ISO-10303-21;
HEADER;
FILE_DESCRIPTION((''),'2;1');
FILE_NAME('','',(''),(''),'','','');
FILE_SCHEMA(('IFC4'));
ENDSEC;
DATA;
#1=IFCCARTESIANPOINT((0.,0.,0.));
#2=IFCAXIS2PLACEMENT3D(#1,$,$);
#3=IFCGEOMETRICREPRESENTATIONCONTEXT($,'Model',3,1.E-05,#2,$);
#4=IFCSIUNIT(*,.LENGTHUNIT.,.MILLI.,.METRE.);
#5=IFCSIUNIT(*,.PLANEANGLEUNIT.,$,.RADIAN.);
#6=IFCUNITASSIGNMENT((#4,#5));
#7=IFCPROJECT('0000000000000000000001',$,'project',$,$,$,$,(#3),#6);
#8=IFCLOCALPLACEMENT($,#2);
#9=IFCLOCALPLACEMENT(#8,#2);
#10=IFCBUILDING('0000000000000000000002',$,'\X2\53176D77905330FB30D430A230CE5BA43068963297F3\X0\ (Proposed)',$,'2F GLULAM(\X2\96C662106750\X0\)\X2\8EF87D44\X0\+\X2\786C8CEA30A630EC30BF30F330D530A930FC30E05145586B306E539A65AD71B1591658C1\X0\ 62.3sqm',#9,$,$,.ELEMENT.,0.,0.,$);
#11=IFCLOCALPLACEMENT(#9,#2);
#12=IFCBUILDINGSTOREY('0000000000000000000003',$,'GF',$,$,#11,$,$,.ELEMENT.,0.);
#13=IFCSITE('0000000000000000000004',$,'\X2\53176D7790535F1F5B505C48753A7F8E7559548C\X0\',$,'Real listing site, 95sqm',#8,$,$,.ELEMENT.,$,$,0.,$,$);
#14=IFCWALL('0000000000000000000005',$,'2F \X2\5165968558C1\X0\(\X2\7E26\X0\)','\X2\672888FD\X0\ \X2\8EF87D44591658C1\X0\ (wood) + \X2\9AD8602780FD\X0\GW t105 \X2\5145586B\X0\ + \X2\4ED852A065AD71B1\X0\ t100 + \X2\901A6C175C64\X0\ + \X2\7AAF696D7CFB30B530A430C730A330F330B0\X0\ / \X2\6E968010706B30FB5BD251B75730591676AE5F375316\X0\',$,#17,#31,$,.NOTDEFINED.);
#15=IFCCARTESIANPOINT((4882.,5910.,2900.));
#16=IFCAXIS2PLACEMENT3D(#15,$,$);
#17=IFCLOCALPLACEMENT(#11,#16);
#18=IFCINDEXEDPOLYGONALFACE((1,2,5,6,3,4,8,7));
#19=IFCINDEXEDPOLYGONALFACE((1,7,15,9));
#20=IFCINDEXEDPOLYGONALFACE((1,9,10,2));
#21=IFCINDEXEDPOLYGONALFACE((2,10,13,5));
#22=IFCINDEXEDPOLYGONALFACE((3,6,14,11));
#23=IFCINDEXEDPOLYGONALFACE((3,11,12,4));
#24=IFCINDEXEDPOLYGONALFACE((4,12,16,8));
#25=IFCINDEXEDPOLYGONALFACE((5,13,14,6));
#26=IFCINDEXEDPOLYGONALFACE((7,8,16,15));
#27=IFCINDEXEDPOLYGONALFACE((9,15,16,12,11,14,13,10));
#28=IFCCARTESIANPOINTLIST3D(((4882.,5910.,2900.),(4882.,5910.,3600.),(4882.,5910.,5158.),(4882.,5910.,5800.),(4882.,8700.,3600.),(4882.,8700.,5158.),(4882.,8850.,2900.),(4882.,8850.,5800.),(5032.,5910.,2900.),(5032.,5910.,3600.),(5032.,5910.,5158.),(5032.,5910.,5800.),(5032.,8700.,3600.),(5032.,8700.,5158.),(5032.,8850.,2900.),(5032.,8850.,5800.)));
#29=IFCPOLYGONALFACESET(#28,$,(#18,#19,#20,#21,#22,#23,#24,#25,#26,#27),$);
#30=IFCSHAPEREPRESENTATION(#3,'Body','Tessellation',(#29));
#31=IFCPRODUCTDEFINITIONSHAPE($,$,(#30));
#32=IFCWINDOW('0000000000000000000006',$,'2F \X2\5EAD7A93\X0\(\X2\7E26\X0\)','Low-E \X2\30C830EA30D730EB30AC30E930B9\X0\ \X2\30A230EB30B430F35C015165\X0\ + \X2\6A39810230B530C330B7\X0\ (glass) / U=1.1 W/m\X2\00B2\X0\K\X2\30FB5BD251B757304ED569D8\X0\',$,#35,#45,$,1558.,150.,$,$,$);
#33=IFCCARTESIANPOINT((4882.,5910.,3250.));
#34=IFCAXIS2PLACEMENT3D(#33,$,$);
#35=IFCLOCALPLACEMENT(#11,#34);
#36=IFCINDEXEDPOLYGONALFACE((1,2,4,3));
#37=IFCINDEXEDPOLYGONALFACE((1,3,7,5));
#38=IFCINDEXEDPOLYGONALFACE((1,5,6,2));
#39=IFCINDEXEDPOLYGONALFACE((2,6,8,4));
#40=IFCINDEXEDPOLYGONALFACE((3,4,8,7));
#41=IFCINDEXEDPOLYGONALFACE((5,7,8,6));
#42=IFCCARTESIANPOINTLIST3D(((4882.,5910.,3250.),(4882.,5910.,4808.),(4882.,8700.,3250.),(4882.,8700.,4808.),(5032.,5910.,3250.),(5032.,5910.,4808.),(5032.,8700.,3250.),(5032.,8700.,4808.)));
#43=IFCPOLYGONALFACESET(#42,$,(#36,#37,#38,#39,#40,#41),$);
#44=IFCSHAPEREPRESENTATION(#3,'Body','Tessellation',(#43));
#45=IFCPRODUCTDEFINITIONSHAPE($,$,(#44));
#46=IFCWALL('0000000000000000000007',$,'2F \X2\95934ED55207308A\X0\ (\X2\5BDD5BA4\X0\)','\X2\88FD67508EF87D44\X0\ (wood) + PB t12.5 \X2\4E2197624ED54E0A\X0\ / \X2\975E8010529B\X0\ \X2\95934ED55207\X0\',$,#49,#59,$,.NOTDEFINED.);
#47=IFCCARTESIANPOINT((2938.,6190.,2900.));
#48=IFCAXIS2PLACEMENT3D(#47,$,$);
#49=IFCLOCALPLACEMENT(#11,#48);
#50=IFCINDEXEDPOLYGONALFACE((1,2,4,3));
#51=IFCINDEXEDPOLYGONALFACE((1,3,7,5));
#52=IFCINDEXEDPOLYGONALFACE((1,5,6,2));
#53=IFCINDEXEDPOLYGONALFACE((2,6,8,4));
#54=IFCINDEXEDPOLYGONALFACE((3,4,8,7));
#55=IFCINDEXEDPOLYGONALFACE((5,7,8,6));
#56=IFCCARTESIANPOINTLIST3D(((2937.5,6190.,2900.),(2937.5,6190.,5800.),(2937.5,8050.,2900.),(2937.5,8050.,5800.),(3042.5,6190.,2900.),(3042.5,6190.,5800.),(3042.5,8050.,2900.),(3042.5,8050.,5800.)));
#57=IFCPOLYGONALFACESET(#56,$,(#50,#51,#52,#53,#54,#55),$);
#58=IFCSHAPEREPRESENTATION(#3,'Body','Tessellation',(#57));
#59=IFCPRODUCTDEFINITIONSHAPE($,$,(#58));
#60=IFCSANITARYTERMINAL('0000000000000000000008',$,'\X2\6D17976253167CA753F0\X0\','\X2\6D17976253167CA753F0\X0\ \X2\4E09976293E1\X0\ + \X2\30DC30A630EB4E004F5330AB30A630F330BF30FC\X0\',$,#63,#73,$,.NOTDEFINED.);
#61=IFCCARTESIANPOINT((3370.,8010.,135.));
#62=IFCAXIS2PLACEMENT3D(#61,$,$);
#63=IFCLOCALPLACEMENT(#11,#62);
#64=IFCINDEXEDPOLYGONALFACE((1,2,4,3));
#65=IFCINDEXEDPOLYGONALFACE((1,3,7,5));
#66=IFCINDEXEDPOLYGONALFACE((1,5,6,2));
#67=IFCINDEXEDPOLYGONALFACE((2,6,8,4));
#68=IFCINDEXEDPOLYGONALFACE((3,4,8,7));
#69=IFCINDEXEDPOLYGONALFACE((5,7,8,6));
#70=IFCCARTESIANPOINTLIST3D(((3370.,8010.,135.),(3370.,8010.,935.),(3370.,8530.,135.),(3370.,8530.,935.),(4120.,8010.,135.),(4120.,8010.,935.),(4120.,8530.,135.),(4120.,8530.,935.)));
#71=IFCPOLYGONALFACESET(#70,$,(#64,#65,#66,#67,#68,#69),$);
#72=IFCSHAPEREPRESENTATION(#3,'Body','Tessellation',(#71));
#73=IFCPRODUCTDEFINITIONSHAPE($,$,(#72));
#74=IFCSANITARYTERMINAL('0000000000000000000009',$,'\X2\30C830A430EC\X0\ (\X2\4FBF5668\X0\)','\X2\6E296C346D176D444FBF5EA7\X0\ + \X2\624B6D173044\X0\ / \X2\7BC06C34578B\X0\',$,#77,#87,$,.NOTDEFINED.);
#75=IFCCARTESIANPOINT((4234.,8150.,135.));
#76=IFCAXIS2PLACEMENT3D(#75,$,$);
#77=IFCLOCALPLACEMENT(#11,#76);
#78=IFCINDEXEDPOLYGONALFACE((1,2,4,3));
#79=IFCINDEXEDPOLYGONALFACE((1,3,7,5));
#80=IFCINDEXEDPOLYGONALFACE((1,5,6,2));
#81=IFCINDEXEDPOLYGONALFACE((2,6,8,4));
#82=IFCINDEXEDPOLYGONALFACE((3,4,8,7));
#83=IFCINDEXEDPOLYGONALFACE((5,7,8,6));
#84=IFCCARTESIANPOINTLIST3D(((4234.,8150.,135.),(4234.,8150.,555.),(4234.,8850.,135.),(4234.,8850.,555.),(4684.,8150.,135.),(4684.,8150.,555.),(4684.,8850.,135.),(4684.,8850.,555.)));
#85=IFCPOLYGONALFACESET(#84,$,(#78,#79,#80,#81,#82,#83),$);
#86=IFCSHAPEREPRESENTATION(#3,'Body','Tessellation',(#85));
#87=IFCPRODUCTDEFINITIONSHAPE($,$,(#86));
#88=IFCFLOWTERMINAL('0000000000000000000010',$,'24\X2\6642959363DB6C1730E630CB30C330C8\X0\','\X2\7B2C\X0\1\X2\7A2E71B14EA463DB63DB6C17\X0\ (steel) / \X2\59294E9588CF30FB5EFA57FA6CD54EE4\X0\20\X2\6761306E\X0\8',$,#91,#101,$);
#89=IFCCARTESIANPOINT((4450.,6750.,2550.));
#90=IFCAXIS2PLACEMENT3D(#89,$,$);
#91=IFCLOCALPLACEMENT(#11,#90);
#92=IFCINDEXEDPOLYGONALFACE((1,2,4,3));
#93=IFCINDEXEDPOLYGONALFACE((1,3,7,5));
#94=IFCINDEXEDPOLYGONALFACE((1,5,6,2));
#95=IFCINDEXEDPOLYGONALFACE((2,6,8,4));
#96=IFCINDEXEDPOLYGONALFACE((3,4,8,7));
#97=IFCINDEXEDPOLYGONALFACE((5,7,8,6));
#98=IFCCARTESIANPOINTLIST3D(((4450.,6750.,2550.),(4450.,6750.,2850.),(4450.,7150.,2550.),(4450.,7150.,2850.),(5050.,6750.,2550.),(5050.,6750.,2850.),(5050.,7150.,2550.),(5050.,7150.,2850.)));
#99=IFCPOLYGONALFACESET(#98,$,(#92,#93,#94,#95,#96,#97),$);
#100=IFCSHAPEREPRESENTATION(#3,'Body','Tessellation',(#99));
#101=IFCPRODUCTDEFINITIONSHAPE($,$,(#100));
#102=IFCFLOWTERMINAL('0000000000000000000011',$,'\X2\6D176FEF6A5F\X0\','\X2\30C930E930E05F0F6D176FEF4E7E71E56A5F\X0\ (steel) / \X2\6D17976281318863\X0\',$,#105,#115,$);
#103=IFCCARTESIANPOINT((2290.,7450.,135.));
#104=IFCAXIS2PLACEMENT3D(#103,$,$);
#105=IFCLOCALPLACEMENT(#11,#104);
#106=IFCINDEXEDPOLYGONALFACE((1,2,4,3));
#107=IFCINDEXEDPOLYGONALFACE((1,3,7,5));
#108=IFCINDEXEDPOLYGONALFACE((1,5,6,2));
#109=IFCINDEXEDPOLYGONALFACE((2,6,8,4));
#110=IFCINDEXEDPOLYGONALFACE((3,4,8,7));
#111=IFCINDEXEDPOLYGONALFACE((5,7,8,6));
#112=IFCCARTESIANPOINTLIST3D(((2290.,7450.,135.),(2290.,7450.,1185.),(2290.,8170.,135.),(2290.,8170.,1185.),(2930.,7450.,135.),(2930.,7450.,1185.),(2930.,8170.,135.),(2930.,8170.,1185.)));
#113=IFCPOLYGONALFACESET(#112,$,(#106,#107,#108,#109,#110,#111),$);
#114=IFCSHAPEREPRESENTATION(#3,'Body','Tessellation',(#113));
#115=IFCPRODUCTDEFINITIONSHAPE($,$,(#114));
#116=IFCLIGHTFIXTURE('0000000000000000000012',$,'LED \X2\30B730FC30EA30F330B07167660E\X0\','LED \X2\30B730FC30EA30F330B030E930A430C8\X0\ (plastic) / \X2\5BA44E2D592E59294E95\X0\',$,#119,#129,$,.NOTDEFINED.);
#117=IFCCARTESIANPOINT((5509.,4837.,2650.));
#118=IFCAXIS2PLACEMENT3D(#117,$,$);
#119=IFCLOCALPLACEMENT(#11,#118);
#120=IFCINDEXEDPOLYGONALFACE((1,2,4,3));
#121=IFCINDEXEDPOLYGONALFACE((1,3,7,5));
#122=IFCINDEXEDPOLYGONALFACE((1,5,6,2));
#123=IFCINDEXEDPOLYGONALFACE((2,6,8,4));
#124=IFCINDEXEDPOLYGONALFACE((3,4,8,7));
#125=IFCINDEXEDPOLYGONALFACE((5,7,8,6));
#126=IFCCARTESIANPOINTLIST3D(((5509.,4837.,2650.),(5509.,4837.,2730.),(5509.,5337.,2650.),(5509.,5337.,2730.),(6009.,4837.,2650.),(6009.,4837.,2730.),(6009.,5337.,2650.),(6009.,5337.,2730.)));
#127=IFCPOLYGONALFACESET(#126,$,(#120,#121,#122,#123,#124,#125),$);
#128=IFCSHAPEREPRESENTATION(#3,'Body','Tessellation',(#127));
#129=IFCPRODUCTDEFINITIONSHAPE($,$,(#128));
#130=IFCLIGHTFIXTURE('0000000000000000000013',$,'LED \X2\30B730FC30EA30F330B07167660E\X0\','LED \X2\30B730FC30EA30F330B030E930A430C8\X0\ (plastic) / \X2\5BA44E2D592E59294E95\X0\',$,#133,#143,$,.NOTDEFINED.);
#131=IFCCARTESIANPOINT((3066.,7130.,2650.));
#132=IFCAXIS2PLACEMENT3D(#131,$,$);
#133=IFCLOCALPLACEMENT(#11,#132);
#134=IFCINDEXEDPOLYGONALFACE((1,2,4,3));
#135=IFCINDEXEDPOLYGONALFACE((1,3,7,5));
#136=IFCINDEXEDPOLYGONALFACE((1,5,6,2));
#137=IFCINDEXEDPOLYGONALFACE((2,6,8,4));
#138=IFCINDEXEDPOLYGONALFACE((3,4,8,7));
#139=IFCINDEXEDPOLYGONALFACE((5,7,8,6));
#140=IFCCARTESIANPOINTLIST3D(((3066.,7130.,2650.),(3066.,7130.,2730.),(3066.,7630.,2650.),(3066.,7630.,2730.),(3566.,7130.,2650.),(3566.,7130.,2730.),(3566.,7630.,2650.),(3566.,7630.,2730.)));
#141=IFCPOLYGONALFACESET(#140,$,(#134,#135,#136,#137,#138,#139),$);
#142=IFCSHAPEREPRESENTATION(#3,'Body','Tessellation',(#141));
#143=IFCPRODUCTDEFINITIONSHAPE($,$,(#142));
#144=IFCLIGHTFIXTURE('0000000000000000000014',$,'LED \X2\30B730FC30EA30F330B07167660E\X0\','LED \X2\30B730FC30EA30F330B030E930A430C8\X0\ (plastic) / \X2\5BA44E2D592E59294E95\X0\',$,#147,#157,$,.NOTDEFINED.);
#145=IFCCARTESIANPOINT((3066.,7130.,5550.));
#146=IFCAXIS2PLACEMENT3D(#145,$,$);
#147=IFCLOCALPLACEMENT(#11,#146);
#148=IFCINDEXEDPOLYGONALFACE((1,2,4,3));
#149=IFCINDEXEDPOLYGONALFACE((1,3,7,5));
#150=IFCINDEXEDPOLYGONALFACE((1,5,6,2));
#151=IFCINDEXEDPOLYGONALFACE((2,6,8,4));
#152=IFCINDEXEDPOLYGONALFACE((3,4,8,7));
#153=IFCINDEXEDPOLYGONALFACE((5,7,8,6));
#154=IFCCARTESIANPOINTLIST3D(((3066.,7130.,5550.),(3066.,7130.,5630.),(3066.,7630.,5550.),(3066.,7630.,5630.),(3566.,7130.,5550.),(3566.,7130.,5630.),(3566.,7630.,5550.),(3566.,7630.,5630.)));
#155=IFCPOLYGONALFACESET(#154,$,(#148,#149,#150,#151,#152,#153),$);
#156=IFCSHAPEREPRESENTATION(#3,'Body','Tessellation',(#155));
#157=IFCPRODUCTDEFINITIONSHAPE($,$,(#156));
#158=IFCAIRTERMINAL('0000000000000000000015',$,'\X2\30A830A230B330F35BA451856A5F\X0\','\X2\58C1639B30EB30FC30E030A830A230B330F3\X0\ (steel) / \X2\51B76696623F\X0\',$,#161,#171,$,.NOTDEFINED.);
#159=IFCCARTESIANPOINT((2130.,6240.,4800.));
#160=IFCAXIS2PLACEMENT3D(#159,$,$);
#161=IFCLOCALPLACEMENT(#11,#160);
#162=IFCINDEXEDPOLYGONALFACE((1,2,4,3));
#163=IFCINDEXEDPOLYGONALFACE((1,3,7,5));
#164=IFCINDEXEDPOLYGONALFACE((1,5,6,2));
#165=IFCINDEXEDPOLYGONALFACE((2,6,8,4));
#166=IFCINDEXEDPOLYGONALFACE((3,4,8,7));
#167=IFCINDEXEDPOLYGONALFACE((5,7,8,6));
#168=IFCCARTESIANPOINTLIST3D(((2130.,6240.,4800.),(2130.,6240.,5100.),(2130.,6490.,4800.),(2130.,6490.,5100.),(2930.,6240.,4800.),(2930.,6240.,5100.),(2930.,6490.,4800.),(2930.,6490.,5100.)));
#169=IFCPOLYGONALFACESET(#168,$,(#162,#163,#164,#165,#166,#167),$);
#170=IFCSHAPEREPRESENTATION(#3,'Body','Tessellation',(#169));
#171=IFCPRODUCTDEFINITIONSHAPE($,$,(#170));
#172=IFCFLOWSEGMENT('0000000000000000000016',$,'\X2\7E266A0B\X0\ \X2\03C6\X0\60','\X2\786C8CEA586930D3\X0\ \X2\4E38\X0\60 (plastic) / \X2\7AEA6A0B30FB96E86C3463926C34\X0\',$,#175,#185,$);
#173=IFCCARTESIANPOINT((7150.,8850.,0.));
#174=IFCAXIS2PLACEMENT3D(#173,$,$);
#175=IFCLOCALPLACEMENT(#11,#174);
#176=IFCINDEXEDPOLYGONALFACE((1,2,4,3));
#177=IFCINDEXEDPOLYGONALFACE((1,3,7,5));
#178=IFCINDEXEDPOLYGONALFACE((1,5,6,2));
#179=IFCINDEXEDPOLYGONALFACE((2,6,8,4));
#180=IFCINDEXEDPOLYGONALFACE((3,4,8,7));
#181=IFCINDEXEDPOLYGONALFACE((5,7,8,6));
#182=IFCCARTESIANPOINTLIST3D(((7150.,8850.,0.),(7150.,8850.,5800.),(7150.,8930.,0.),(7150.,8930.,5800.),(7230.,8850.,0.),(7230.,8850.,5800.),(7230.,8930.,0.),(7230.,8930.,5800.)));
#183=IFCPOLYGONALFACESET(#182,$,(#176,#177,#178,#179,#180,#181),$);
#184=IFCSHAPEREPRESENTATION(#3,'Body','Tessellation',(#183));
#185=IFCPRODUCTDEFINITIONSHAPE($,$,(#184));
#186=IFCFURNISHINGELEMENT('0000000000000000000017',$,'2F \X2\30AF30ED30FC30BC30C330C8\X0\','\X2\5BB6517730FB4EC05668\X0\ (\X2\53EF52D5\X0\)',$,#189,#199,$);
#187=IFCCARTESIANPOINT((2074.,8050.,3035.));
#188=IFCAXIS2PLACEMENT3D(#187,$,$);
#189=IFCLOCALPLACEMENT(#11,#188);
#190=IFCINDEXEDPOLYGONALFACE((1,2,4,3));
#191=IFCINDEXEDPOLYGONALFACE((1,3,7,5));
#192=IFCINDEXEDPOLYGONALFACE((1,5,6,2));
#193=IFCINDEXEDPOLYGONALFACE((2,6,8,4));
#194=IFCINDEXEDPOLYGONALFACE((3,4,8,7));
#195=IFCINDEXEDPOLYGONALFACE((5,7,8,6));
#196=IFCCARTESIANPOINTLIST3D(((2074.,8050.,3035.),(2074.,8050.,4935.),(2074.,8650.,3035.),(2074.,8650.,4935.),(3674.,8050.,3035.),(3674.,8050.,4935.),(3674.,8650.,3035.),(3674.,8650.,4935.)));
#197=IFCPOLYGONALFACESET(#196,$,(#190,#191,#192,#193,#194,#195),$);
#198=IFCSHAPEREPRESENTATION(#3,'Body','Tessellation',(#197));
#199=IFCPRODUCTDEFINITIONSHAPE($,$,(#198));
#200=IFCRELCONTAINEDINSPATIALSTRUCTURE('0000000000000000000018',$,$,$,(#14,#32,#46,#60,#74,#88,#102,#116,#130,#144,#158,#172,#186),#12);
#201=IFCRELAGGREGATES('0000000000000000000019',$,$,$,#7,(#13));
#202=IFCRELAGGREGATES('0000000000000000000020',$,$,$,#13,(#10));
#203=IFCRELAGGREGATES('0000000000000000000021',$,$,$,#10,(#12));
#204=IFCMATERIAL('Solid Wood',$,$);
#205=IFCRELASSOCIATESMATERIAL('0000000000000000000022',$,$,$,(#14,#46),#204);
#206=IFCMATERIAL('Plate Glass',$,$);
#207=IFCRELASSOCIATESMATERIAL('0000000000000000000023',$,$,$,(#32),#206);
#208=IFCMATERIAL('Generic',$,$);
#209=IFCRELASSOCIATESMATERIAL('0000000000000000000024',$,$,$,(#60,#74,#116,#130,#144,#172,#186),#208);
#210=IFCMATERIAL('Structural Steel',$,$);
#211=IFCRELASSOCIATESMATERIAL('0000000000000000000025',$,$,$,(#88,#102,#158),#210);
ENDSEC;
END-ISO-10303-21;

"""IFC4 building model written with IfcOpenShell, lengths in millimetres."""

from ifc_helpers import new_model, si_unit, frame, frame_2d, origin, place, context, project, spatial, rectangle, extrude, material, element, fill, save


model = new_model("IFC4")

# Units and contexts
model_context = context("Model", 3, precision=1e-05, world=origin())
ifc_project = project(units=[si_unit("LENGTHUNIT", "METRE", prefix="MILLI"), si_unit("PLANEANGLEUNIT", "RADIAN")], contexts=[model_context])

# Site, building, storey
site_placement = place(None, origin())
site = spatial("IfcSite", under=ifc_project, at=site_placement, Name="北海道弟子屈町美留和", ObjectType="Real listing site, 95sqm", CompositionType="ELEMENT", RefElevation=0.0)
building_placement = place(site_placement, origin())
building = spatial("IfcBuilding", under=site, at=building_placement, Name="北海道・ピアノ室と防音 (Proposed)", ObjectType="2F GLULAM(集成材)軸組+硬質ウレタンフォーム充填の厚断熱外壁 62.3sqm", CompositionType="ELEMENT", ElevationOfRefHeight=0.0, ElevationOfTerrain=0.0)
storey_placement = place(building_placement, origin())
storey = spatial("IfcBuildingStorey", under=building, at=storey_placement, Name="GF", CompositionType="ELEMENT", Elevation=0.0)

# Shared definitions
ifc_material_1 = material(Name="Solid Wood")

# Shared definitions
ifc_material_2 = material(Name="Plate Glass")

# Wall, opening, window
wall_1_placement = place(storey_placement, frame((4882.0, 5910.0, 2900.0)))
wall_1 = element("IfcWall", 1, at=wall_1_placement, inside=storey, material=ifc_material_1, Name="2F 入隅壁(縦)", Description="木製 軸組外壁 (wood) + 高性能GW t105 充填 + 付加断熱 t100 + 通気層 + 窯業系サイディング / 準耐火・寒冷地外皮強化", PredefinedType="NOTDEFINED", context=model_context, shape_type="SweptSolid", body=[
    extrude(rectangle(XDim=150.0, YDim=2940.0, at=frame_2d((75.0, 1470.0))), frame((4882.0, 5910.0, 2900.0)), (0.0, 0.0, 1.0), 2900.0),
])
opening_1_placement = place(storey_placement, frame((4882.0, 5910.0, 3250.0)))
opening_1 = element("IfcOpeningElement", 2, at=opening_1_placement, cuts=wall_1, PredefinedType="NOTDEFINED", context=model_context, shape_type="SweptSolid", body=[
    extrude(rectangle(XDim=150.0, YDim=2790.0, at=frame_2d((75.0, 1395.0))), frame((4882.0, 5910.0, 3250.0)), (0.0, 0.0, 1.0), 1558.0),
])
window_1_placement = place(storey_placement, frame((4882.0, 5910.0, 3250.0)))
window_1 = element("IfcWindow", 3, at=window_1_placement, inside=storey, material=ifc_material_2, Name="2F 庭窓(縦)", Description="Low-E トリプルガラス アルゴン封入 + 樹脂サッシ (glass) / U=1.1 W/m²K・寒冷地仕様", OverallHeight=1558.0, OverallWidth=150.0, context=model_context, shape_type="SweptSolid", body=[
    extrude(rectangle(XDim=150.0, YDim=2790.0, at=frame_2d((75.0, 1395.0))), frame((4882.0, 5910.0, 3250.0)), (0.0, 0.0, 1.0), 1558.0),
])
fill(opening_1, window_1)

# Wall
wall_2_placement = place(storey_placement, frame((2938.0, 6190.0, 2900.0)))
element("IfcWall", 4, at=wall_2_placement, inside=storey, material=ifc_material_1, Name="2F 間仕切り (寝室)", Description="製材軸組 (wood) + PB t12.5 両面仕上 / 非耐力 間仕切", PredefinedType="NOTDEFINED", context=model_context, shape_type="SweptSolid", body=[
    extrude(rectangle(XDim=105.0, YDim=1860.0, at=frame_2d((52.0, 930.0))), frame((2938.0, 6190.0, 2900.0)), (0.0, 0.0, 1.0), 2900.0),
])

# Sanitary terminals
ifc_material_3 = material(Name="Generic")
sanitary_terminal_1_placement = place(storey_placement, frame((3370.0, 8010.0, 135.0)))
element("IfcSanitaryTerminal", 5, at=sanitary_terminal_1_placement, inside=storey, material=ifc_material_3, Name="洗面化粧台", Description="洗面化粧台 三面鏡 + ボウル一体カウンター", PredefinedType="NOTDEFINED", context=model_context, shape_type="SweptSolid", body=[
    extrude(rectangle(XDim=750.0, YDim=520.0, at=frame_2d((375.0, 260.0))), frame((3370.0, 8010.0, 135.0)), (0.0, 0.0, 1.0), 800.0),
])
sanitary_terminal_2_placement = place(storey_placement, frame((4234.0, 8150.0, 135.0)))
element("IfcSanitaryTerminal", 6, at=sanitary_terminal_2_placement, inside=storey, material=ifc_material_3, Name="トイレ (便器)", Description="温水洗浄便座 + 手洗い / 節水型", PredefinedType="NOTDEFINED", context=model_context, shape_type="SweptSolid", body=[
    extrude(rectangle(XDim=450.0, YDim=700.0, at=frame_2d((225.0, 350.0))), frame((4234.0, 8150.0, 135.0)), (0.0, 0.0, 1.0), 420.0),
])

# Flow terminals
ifc_material_4 = material(Name="Structural Steel")
flow_terminal_1_placement = place(storey_placement, frame((4450.0, 6750.0, 2550.0)))
element("IfcFlowTerminal", 7, at=flow_terminal_1_placement, inside=storey, material=ifc_material_4, Name="24時間換気ユニット", Description="第1種熱交換換気 (steel) / 天井裏・建基法令20条の8", context=model_context, shape_type="SweptSolid", body=[
    extrude(rectangle(XDim=600.0, YDim=400.0, at=frame_2d((300.0, 200.0))), frame((4450.0, 6750.0, 2550.0)), (0.0, 0.0, 1.0), 300.0),
])
flow_terminal_2_placement = place(storey_placement, frame((2290.0, 7450.0, 135.0)))
element("IfcFlowTerminal", 8, at=flow_terminal_2_placement, inside=storey, material=ifc_material_4, Name="洗濯機", Description="ドラム式洗濯乾燥機 (steel) / 洗面脱衣", context=model_context, shape_type="SweptSolid", body=[
    extrude(rectangle(XDim=640.0, YDim=720.0, at=frame_2d((320.0, 360.0))), frame((2290.0, 7450.0, 135.0)), (0.0, 0.0, 1.0), 1050.0),
])

# Light fixtures
light_fixture_1_placement = place(storey_placement, frame((5509.0, 4837.0, 2650.0)))
element("IfcLightFixture", 9, at=light_fixture_1_placement, inside=storey, material=ifc_material_3, Name="LED シーリング照明", Description="LED シーリングライト (plastic) / 室中央天井", PredefinedType="NOTDEFINED", context=model_context, shape_type="SweptSolid", body=[
    extrude(rectangle(XDim=500.0, YDim=500.0, at=frame_2d((250.0, 250.0))), frame((5509.0, 4837.0, 2650.0)), (0.0, 0.0, 1.0), 80.0),
])
light_fixture_2_placement = place(storey_placement, frame((3066.0, 7130.0, 2650.0)))
element("IfcLightFixture", 10, at=light_fixture_2_placement, inside=storey, material=ifc_material_3, Name="LED シーリング照明", Description="LED シーリングライト (plastic) / 室中央天井", PredefinedType="NOTDEFINED", context=model_context, shape_type="SweptSolid", body=[
    extrude(rectangle(XDim=500.0, YDim=500.0, at=frame_2d((250.0, 250.0))), frame((3066.0, 7130.0, 2650.0)), (0.0, 0.0, 1.0), 80.0),
])
light_fixture_3_placement = place(storey_placement, frame((3066.0, 7130.0, 5550.0)))
element("IfcLightFixture", 11, at=light_fixture_3_placement, inside=storey, material=ifc_material_3, Name="LED シーリング照明", Description="LED シーリングライト (plastic) / 室中央天井", PredefinedType="NOTDEFINED", context=model_context, shape_type="SweptSolid", body=[
    extrude(rectangle(XDim=500.0, YDim=500.0, at=frame_2d((250.0, 250.0))), frame((3066.0, 7130.0, 5550.0)), (0.0, 0.0, 1.0), 80.0),
])

# Air terminal
air_terminal_placement = place(storey_placement, frame((2130.0, 6240.0, 4800.0)))
element("IfcAirTerminal", 12, at=air_terminal_placement, inside=storey, material=ifc_material_4, Name="エアコン室内機", Description="壁掛ルームエアコン (steel) / 冷暖房", PredefinedType="NOTDEFINED", context=model_context, shape_type="SweptSolid", body=[
    extrude(rectangle(XDim=800.0, YDim=250.0, at=frame_2d((400.0, 125.0))), frame((2130.0, 6240.0, 4800.0)), (0.0, 0.0, 1.0), 300.0),
])

# Flow segment
flow_segment_placement = place(storey_placement, frame((7150.0, 8850.0, 0.0)))
element("IfcFlowSegment", 13, at=flow_segment_placement, inside=storey, material=ifc_material_3, Name="縦樋 φ60", Description="硬質塩ビ 丸60 (plastic) / 竪樋・雨水排水", context=model_context, shape_type="SweptSolid", body=[
    extrude(rectangle(XDim=80.0, YDim=80.0, at=frame_2d((40.0, 40.0))), frame((7150.0, 8850.0, 0.0)), (0.0, 0.0, 1.0), 5800.0),
])

# Furnishing element
furnishing_1_placement = place(storey_placement, frame((2074.0, 8050.0, 3035.0)))
element("IfcFurnishingElement", 14, at=furnishing_1_placement, inside=storey, material=ifc_material_3, Name="2F クローゼット", Description="家具・什器 (可動)", context=model_context, shape_type="SweptSolid", body=[
    extrude(rectangle(XDim=1600.0, YDim=600.0, at=frame_2d((800.0, 300.0))), frame((2074.0, 8050.0, 3035.0)), (0.0, 0.0, 1.0), 1900.0),
])

save(model, "model.ifc")
